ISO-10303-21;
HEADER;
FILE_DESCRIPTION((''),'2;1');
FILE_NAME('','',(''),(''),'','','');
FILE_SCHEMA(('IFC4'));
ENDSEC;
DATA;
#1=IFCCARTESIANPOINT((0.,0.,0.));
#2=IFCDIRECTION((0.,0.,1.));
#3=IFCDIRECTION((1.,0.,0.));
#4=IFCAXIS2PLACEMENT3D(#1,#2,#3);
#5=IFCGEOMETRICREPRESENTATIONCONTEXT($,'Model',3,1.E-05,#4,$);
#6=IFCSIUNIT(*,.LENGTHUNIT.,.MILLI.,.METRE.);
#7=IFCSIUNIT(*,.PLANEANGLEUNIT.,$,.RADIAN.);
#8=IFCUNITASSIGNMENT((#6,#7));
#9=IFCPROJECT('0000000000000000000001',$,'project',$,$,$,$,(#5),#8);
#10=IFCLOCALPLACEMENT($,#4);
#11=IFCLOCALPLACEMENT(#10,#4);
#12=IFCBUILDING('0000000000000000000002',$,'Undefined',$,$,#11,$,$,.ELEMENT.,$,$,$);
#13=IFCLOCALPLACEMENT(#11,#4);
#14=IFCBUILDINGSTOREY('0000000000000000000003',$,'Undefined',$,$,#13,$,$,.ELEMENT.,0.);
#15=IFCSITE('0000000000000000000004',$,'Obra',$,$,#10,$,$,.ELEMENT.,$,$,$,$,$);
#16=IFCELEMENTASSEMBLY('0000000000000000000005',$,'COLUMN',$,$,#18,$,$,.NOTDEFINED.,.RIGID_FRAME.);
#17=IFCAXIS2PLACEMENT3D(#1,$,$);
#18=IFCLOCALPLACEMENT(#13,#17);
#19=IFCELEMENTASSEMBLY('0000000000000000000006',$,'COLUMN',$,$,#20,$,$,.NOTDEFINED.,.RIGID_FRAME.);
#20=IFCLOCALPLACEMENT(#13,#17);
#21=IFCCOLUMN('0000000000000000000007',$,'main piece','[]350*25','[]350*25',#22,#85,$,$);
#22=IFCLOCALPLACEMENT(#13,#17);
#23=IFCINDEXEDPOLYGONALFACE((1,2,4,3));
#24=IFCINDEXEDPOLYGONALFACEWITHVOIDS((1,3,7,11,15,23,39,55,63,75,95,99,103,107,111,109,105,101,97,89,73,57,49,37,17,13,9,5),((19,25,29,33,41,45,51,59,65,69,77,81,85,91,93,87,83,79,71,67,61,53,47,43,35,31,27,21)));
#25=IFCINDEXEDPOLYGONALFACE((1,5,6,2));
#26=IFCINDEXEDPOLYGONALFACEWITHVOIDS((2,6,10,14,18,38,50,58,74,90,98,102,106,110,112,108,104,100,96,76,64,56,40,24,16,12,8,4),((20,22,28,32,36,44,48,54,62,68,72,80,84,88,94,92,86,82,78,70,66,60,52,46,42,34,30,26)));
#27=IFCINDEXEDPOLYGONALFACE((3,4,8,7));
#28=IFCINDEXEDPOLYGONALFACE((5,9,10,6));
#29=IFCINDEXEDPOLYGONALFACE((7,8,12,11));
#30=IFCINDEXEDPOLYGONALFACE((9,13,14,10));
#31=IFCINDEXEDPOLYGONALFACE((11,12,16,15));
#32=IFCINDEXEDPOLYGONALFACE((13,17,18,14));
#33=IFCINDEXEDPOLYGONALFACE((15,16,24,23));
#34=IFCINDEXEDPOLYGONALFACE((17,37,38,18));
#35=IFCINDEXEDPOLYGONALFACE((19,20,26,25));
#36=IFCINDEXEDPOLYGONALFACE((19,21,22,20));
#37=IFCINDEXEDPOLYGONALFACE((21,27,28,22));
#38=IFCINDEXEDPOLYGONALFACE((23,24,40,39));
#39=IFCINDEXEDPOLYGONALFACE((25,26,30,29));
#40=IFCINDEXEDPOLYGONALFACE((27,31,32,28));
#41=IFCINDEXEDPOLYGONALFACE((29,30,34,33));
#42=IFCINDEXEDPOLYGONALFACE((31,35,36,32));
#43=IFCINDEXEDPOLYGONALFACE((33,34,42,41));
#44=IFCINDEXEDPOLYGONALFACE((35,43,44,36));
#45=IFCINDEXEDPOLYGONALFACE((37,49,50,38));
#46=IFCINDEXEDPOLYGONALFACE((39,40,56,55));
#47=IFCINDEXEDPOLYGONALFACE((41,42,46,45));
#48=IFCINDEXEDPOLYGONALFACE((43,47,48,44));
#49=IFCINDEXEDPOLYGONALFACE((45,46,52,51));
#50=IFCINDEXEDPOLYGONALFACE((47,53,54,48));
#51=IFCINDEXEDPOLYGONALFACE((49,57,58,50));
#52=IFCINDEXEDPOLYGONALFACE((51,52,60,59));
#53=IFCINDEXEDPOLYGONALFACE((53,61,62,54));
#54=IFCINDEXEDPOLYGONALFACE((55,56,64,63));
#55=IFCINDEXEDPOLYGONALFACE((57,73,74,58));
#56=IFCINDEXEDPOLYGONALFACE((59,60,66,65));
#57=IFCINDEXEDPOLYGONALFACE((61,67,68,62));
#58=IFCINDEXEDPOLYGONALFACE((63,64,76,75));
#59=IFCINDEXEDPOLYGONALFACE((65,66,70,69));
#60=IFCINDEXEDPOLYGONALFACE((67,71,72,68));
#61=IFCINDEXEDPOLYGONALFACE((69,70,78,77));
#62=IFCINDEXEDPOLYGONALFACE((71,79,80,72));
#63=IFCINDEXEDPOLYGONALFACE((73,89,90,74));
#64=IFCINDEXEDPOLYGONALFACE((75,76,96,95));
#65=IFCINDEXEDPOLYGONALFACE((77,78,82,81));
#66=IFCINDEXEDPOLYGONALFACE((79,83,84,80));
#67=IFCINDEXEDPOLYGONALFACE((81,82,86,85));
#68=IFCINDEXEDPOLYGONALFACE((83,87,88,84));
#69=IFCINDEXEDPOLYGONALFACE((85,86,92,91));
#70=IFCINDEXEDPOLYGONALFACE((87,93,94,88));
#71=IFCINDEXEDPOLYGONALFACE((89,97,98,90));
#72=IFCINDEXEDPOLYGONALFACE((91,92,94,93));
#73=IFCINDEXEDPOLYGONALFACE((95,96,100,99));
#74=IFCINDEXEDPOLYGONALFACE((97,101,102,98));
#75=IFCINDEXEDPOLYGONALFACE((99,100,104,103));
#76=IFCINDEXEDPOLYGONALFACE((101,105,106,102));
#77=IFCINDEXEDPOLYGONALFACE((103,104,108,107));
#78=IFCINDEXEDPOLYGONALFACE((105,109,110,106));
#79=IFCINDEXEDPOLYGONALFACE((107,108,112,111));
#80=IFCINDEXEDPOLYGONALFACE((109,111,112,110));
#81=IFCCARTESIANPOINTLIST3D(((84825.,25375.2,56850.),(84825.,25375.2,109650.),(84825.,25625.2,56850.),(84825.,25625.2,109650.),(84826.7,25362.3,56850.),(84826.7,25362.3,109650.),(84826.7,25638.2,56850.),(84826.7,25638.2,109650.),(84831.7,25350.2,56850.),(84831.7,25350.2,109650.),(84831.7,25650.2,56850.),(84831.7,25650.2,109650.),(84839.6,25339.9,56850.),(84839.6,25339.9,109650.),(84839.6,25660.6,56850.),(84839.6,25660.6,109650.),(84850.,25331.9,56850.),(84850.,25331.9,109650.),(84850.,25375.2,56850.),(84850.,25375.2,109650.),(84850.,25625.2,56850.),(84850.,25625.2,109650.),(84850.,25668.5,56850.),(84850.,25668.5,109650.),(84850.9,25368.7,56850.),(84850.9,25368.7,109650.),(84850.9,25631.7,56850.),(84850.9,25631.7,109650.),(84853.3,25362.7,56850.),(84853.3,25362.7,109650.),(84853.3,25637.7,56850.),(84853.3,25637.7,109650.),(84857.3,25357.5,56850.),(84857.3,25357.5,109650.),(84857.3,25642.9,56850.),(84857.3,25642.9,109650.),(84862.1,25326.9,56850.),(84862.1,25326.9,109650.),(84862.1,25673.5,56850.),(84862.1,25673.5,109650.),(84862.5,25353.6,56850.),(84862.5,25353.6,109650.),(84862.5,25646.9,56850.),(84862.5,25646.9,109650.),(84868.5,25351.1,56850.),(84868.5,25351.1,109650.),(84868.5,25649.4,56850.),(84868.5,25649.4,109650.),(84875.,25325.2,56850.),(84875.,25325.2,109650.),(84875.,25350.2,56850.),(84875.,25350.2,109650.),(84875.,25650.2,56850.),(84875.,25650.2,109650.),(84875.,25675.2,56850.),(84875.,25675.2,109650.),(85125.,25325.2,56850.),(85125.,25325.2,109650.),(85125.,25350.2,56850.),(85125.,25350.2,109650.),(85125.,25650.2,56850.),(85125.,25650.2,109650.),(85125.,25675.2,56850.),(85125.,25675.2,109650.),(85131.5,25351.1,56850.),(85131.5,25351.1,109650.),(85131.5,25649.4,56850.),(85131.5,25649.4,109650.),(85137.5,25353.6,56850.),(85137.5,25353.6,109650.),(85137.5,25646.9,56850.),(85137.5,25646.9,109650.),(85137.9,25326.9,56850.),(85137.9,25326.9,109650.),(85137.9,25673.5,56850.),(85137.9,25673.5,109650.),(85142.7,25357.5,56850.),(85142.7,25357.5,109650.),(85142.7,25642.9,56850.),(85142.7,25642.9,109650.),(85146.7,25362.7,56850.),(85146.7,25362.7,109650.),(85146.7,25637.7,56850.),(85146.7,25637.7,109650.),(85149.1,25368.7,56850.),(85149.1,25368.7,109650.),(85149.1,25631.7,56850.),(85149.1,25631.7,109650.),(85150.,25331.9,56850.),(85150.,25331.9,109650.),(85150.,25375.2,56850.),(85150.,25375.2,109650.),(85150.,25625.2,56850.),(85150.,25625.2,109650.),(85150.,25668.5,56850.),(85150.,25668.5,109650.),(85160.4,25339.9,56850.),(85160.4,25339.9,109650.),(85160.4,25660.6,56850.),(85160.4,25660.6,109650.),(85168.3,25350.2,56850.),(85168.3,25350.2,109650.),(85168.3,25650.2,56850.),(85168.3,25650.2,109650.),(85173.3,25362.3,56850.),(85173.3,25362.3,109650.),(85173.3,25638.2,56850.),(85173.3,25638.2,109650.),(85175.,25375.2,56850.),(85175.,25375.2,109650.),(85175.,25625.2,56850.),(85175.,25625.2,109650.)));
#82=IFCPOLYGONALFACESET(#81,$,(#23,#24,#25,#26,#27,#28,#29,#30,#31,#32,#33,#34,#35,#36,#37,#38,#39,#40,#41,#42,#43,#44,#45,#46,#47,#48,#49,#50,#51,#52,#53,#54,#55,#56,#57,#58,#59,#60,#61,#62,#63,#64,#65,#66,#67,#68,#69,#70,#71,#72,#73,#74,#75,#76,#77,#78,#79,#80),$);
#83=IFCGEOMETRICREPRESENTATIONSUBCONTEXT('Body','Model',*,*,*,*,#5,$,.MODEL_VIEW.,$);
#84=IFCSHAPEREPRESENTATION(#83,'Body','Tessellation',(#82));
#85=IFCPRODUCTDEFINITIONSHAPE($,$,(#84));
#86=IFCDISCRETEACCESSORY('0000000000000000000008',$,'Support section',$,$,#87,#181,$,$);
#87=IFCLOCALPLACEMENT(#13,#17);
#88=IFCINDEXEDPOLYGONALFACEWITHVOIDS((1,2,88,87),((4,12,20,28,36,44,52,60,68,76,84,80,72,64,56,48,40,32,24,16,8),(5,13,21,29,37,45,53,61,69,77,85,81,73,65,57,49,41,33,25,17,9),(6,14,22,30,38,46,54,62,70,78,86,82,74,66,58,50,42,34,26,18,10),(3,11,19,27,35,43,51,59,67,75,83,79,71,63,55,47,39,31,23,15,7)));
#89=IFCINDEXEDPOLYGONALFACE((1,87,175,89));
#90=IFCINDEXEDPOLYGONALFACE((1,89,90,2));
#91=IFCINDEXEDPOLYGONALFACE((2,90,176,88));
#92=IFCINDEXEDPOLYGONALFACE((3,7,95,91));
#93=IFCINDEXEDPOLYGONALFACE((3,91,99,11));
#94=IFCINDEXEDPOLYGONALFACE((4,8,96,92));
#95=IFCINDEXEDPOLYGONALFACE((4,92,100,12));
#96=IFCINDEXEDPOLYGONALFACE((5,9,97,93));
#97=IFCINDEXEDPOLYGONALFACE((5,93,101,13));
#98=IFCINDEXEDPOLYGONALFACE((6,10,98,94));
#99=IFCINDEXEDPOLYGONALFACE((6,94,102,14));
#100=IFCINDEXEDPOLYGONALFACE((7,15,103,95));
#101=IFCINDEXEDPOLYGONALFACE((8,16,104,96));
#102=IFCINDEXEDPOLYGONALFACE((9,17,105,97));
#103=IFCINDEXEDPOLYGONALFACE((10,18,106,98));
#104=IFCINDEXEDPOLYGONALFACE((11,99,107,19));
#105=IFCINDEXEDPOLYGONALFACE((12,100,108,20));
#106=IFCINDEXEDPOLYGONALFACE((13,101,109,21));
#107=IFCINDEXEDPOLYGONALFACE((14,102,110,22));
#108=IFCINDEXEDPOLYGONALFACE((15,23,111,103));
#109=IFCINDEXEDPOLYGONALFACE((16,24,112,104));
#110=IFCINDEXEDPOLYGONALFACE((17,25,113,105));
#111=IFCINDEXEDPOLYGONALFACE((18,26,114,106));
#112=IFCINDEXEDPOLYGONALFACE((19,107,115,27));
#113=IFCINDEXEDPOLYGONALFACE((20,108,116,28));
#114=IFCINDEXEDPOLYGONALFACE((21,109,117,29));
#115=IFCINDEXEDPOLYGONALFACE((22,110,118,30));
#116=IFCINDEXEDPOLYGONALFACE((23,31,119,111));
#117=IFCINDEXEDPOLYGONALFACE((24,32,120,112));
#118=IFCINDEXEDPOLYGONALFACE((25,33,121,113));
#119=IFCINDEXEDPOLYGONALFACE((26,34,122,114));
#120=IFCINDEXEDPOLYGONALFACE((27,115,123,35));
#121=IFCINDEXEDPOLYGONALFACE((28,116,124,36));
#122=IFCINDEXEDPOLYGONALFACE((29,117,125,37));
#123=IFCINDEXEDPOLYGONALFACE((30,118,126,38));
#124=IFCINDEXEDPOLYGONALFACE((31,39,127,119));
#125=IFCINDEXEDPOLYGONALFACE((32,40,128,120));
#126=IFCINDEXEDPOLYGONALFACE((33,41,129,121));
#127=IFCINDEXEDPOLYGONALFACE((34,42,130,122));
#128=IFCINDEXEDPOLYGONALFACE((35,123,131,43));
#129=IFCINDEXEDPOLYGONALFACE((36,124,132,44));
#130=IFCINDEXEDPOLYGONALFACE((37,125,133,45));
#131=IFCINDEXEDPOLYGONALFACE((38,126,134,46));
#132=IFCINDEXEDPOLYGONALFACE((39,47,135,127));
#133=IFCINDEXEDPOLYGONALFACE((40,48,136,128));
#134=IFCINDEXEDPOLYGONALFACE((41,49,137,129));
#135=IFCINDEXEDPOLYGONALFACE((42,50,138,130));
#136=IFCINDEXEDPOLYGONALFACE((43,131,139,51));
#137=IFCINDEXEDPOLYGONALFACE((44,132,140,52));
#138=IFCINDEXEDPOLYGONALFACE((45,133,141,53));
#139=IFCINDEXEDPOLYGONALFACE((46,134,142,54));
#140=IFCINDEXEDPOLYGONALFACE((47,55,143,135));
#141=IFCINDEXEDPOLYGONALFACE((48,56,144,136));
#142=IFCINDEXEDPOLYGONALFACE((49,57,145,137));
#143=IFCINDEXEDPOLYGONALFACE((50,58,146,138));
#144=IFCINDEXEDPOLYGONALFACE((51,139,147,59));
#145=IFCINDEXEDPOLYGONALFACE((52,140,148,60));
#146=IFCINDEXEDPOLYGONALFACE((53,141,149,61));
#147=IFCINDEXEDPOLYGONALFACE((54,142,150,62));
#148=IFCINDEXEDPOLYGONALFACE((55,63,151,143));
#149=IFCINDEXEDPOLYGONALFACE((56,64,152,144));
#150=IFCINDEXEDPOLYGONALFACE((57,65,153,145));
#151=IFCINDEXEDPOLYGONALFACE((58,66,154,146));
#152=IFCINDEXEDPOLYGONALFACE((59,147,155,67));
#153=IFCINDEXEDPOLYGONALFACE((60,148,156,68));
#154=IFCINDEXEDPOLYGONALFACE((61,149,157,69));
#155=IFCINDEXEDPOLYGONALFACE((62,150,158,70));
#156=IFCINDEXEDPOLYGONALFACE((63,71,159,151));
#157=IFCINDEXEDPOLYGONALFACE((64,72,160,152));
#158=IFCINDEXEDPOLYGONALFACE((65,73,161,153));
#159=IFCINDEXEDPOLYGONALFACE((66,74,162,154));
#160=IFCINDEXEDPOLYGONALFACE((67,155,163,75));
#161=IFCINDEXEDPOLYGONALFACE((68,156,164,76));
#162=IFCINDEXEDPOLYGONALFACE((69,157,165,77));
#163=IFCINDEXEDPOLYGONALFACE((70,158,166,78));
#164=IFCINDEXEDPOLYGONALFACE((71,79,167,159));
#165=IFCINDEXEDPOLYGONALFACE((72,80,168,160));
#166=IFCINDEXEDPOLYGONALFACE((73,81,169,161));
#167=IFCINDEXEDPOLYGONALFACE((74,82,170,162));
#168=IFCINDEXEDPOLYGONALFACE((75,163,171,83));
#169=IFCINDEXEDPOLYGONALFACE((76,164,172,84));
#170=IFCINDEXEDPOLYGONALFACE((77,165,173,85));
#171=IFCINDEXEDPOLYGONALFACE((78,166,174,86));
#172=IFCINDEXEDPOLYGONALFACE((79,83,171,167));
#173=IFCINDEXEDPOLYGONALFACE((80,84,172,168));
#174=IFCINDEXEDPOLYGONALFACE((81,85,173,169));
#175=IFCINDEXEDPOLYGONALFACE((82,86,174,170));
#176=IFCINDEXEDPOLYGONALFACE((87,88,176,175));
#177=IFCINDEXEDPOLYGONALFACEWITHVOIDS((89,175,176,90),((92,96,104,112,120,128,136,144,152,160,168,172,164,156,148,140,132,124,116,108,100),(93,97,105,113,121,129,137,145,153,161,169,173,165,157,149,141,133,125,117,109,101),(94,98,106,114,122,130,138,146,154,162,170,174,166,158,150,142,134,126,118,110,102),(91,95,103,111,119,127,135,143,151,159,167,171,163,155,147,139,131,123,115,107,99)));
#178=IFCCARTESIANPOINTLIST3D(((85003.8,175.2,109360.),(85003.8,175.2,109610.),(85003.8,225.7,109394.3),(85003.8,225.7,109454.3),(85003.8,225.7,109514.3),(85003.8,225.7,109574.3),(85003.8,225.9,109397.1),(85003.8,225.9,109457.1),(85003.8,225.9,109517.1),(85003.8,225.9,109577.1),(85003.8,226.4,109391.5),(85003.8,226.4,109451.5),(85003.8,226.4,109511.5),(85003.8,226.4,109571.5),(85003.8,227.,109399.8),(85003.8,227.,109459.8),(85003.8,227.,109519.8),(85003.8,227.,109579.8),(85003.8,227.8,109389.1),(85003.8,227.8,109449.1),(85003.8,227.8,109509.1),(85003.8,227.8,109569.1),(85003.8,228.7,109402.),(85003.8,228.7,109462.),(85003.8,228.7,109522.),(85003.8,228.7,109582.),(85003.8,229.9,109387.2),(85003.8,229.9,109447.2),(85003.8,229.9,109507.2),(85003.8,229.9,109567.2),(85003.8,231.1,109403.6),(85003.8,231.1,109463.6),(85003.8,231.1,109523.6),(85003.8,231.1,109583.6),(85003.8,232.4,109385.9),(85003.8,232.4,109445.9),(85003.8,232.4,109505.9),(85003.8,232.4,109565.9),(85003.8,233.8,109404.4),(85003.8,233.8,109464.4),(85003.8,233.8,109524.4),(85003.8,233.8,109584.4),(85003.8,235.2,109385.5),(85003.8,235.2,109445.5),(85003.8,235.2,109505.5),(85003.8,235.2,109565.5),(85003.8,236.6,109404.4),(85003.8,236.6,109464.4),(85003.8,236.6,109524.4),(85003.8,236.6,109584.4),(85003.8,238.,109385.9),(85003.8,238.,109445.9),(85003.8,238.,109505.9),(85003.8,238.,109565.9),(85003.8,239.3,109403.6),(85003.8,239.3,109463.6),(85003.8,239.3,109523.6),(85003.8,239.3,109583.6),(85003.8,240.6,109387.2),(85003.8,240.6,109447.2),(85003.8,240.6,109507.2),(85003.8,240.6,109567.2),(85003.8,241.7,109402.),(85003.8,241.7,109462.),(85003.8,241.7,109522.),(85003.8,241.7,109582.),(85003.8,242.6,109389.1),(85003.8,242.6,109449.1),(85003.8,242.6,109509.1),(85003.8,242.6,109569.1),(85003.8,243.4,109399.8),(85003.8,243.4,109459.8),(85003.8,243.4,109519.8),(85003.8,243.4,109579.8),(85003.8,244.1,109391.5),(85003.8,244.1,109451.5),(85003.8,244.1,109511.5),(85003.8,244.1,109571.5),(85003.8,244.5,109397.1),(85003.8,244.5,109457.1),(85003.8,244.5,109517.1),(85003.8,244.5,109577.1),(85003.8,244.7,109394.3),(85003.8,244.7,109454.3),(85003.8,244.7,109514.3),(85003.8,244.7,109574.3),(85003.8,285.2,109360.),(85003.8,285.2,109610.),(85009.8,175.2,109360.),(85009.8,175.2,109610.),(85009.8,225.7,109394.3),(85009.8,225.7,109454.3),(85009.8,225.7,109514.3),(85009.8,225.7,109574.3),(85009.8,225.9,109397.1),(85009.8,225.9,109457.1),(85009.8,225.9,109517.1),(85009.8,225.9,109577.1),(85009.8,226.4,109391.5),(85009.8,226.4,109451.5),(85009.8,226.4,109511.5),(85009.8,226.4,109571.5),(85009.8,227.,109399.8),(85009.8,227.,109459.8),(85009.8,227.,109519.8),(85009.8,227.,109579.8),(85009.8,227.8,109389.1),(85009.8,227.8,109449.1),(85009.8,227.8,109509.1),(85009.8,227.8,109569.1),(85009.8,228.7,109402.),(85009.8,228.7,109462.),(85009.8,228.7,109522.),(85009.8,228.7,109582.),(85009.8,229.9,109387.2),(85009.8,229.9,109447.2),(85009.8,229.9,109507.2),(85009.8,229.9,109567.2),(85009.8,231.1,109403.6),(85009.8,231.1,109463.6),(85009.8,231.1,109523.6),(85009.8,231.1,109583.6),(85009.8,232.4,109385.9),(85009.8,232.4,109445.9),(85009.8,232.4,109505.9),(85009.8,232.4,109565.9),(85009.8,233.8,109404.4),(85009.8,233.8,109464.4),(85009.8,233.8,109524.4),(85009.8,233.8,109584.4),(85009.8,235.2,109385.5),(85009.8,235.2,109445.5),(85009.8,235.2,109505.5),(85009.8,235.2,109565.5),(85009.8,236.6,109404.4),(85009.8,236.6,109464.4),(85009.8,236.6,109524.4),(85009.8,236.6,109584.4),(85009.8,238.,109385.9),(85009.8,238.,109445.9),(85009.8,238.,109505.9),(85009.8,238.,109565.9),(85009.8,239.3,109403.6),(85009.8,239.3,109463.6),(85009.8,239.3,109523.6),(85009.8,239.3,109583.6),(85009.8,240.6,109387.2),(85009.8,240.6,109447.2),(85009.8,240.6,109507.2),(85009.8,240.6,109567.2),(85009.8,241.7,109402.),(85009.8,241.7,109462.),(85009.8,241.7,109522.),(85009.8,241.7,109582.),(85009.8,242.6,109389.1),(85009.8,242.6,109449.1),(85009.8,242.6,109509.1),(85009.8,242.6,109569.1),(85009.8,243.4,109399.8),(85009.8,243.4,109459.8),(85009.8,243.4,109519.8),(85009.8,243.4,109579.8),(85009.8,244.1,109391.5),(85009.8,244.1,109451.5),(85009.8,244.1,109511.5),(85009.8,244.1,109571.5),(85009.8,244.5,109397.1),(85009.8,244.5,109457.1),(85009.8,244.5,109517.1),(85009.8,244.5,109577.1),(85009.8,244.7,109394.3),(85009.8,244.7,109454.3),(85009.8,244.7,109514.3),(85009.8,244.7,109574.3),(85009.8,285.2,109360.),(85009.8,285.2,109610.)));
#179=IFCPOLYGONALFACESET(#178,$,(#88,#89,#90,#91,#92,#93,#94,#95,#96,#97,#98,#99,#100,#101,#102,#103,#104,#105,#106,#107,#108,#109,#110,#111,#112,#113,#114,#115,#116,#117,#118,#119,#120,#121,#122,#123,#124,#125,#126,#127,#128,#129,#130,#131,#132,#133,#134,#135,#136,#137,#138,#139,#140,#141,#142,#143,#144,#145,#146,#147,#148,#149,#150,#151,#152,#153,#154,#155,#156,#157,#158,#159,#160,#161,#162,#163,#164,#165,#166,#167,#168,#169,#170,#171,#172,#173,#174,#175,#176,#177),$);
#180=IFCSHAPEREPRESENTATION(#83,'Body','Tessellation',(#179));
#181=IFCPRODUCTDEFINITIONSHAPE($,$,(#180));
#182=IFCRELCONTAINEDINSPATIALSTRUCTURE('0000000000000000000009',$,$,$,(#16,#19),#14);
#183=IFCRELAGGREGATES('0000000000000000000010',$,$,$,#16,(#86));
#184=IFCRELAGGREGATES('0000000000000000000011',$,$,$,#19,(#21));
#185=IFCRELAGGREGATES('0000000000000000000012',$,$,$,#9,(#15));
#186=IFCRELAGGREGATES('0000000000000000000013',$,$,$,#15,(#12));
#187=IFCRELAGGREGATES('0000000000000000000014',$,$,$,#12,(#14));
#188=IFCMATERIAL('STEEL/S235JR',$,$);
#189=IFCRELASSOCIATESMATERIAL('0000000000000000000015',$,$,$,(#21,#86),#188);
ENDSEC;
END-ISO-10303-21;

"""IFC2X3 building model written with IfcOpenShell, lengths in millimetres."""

from ifc_helpers import new_model, si_unit, frame, origin_with_axes, origin_2d_with_axis, place, context, subcontext, project, spatial, rectangle, hollow_rectangle, circle, extrude, source, transform, mapped, material, element, aggregate, save


model = new_model("IFC2X3")

# Units and contexts
model_context = context("Model", 3, precision=1e-05, world=origin_with_axes())
body_context = subcontext(model_context, "Body", "Model", "MODEL_VIEW")
ifc_project = project(units=[si_unit("LENGTHUNIT", "METRE", prefix="MILLI"), si_unit("PLANEANGLEUNIT", "RADIAN")], contexts=[model_context])

# Site, building, storey
site_placement = place(None, origin_with_axes())
site = spatial("IfcSite", under=ifc_project, at=site_placement, Name="Obra", CompositionType="ELEMENT")
building_placement = place(site_placement, origin_with_axes())
building = spatial("IfcBuilding", under=site, at=building_placement, Name="Undefined", CompositionType="ELEMENT")
storey_placement = place(building_placement, origin_with_axes())
storey = spatial("IfcBuildingStorey", under=building, at=storey_placement, Name="Undefined", CompositionType="ELEMENT", Elevation=0.0)

# Element assemblies, column
assembly_1_placement = place(storey_placement, origin_with_axes())
assembly_1 = element("IfcElementAssembly", 1, at=assembly_1_placement, inside=storey, Name="COLUMN", AssemblyPlace="NOTDEFINED", PredefinedType="RIGID_FRAME")
ifc_material_1 = material(Name="STEEL/S235JR")
assembly_2_placement = place(storey_placement, origin_with_axes())
assembly_2 = element("IfcElementAssembly", 2, at=assembly_2_placement, inside=storey, Name="COLUMN", AssemblyPlace="NOTDEFINED", PredefinedType="RIGID_FRAME")
column_1_placement = place(assembly_2_placement, frame((85000.0, 25500.2, 56850.0), z_axis=(0.0, 0.0, 1.0), x_axis=(0.0, 1.0, 0.0)))
column_1 = element("IfcColumn", 3, at=column_1_placement, material=ifc_material_1, Name="main piece", Description="[]350*25", ObjectType="[]350*25", context=body_context, shape_type="SweptSolid", body=[
    extrude(hollow_rectangle(XDim=350.0, YDim=350.0, WallThickness=25.0, InnerFilletRadius=25.0, OuterFilletRadius=50.0, at=origin_2d_with_axis()), frame((0.0, 0.0, 52800.0), z_axis=(0.0, 0.0, -1.0), x_axis=(0.0, 1.0, 0.0)), (0.0, 0.0, 1.0), 52800.0),
])

# Discrete accessory, opening
discrete_accessory_1_placement = place(assembly_1_placement, frame((85006.8, 230.2, 109360.0), z_axis=(0.0, 0.0, 1.0), x_axis=(0.0, -1.0, 0.0)))
discrete_accessory_1 = element("IfcDiscreteAccessory", 4, at=discrete_accessory_1_placement, material=ifc_material_1, Name="Support section", context=body_context, shape_type="SweptSolid", body=[
    extrude(rectangle(XDim=6.0, YDim=110.0, at=origin_2d_with_axis()), frame((0.0, 0.0, 250.0), z_axis=(0.0, 0.0, -1.0), x_axis=(0.0, 1.0, 0.0)), (0.0, 0.0, 1.0), 250.0),
])
shared_shape_1 = source(origin_with_axes(), body_context, "Body", "SweptSolid", [
    extrude(circle(Radius=9.5, at=origin_2d_with_axis()), frame((0.0, -9.8, 0.0), z_axis=(0.0, 1.0, 0.0), x_axis=(1.0, 0.0, 0.0)), (0.0, 0.0, 1.0), 6.2),
])
opening_1_placement = place(assembly_1_placement, frame((85000.0, 185.2, 109650.0), z_axis=(0.0, 1.0, 0.0), x_axis=(0.0, 0.0, -1.0)))
element("IfcOpeningElement", 5, at=opening_1_placement, cuts=discrete_accessory_1, ObjectType="Opening", context=body_context, shape_type="MappedRepresentation", body=[
    mapped(shared_shape_1, transform((75.0, 0.0, 50.0))),
    mapped(shared_shape_1, transform((135.0, 0.0, 50.0))),
    mapped(shared_shape_1, transform((195.0, 0.0, 50.0))),
    mapped(shared_shape_1, transform((255.0, 0.0, 50.0))),
])
aggregate(assembly_1, [discrete_accessory_1])
aggregate(assembly_2, [column_1])

save(model, "model.ifc")
